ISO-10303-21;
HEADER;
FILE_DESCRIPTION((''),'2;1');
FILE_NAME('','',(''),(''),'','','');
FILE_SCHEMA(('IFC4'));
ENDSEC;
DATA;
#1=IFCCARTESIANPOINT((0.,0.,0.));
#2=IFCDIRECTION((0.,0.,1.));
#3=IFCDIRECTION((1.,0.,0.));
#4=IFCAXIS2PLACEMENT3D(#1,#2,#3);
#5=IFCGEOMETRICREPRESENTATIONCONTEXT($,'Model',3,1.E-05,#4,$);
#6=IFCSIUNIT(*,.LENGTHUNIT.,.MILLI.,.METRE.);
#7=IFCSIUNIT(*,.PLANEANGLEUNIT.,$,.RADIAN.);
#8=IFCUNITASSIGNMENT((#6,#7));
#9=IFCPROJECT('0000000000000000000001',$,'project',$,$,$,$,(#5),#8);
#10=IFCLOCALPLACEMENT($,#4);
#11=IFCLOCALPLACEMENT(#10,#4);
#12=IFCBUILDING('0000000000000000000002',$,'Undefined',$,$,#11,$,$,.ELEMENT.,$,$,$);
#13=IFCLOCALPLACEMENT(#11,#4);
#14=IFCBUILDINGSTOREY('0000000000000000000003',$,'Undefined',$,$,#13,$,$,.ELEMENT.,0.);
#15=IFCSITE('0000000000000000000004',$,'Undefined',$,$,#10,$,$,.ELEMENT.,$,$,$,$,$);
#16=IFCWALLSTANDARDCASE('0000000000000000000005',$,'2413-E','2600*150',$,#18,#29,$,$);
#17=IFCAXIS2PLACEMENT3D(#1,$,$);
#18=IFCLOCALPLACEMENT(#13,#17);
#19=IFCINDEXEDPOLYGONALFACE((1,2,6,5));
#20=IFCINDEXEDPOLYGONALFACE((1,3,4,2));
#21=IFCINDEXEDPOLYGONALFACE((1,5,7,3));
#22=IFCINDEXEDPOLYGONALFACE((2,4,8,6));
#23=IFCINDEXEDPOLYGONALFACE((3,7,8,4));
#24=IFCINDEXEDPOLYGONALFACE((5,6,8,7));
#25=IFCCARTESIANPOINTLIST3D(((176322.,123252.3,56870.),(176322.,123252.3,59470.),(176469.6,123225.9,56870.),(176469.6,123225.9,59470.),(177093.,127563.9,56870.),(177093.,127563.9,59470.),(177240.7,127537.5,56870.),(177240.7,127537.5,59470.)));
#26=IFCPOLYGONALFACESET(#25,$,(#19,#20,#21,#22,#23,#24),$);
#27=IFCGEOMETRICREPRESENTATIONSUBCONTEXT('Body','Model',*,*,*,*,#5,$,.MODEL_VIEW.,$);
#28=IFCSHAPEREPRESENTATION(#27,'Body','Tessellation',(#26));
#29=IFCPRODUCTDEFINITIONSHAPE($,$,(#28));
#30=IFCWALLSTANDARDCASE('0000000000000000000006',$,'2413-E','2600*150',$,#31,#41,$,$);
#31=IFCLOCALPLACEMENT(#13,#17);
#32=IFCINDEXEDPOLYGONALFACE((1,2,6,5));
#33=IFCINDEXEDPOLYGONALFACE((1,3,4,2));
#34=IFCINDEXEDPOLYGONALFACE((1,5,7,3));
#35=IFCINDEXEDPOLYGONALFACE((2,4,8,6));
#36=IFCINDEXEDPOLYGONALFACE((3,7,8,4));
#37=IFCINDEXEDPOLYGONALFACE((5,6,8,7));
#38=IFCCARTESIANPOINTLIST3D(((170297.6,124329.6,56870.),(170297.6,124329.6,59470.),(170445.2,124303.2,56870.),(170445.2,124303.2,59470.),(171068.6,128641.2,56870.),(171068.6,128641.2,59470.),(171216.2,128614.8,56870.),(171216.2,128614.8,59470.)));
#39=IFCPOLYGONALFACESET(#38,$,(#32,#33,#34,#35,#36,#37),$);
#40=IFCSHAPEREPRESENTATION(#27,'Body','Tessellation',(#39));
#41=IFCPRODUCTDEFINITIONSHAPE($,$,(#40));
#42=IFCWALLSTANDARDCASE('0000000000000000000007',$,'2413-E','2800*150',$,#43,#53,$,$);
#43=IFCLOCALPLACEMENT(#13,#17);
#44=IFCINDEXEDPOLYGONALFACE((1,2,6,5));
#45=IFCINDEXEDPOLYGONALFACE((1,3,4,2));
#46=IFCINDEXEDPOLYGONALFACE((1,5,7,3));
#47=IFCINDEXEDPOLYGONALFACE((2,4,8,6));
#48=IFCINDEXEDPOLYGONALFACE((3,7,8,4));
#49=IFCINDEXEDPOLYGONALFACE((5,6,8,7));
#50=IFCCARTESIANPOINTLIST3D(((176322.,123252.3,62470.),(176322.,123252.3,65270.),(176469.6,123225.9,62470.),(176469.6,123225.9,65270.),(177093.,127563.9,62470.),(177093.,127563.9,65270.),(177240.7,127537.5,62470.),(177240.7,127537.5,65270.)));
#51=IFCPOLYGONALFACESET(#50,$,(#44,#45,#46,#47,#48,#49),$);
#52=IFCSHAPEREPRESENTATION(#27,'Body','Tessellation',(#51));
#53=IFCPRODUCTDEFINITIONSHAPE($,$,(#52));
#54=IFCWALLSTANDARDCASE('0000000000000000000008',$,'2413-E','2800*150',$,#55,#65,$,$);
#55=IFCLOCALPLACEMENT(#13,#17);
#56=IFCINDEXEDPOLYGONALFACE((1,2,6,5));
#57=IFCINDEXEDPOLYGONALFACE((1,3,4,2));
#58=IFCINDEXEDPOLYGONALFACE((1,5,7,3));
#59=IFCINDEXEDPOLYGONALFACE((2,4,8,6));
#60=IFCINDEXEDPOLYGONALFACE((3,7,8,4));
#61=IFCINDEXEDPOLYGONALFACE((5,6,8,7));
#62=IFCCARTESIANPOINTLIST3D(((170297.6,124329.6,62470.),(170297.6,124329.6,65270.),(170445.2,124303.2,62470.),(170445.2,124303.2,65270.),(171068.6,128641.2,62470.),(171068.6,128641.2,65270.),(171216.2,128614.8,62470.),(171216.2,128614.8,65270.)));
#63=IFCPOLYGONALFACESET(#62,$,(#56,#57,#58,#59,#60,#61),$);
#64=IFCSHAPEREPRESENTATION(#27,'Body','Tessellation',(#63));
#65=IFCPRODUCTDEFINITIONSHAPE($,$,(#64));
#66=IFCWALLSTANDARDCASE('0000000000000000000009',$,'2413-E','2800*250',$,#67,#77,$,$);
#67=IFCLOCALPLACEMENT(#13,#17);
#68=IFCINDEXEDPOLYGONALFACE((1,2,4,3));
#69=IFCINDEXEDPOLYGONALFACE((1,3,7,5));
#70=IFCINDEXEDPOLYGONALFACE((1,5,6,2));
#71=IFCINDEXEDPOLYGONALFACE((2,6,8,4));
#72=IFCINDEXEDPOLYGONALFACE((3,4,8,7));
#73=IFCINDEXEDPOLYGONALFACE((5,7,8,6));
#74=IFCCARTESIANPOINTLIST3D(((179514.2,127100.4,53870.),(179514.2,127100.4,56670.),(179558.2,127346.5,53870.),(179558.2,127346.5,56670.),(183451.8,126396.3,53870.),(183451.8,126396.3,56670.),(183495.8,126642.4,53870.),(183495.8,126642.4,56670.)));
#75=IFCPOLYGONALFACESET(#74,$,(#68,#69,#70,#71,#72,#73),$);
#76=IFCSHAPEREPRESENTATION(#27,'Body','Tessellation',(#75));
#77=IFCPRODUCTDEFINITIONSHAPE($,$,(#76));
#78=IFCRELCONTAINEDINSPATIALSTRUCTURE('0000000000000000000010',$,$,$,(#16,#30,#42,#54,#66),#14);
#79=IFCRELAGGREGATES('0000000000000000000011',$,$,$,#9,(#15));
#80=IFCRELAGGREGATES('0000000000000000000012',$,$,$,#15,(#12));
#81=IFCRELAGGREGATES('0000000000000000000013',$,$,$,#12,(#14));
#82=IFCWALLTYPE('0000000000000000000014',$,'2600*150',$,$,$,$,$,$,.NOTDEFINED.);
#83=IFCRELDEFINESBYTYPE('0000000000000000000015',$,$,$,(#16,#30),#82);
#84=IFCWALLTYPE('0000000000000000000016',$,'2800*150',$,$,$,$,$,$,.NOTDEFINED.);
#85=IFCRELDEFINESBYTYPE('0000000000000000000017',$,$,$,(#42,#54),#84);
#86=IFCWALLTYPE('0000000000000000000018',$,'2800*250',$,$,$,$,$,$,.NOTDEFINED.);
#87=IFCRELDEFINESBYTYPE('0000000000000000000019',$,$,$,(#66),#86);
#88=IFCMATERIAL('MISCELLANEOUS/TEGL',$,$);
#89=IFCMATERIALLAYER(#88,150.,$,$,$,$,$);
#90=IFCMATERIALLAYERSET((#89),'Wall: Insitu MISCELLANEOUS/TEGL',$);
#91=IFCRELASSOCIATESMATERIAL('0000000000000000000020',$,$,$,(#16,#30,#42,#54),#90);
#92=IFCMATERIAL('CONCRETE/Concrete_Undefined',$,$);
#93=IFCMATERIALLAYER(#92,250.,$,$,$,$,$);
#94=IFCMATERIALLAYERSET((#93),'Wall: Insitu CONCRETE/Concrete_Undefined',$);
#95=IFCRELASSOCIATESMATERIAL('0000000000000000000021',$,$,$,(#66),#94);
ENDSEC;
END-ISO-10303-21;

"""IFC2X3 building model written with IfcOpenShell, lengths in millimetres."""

from ifc_helpers import new_model, si_unit, frame, frame_2d, origin_with_axes, place, context, subcontext, project, spatial, rectangle, extrude, material, layer, layer_set, layer_usage, type_object, element, save


model = new_model("IFC2X3")

# Units and contexts
model_context = context("Model", 3, precision=1e-05, world=origin_with_axes())
body_context = subcontext(model_context, "Body", "Model", "MODEL_VIEW")
ifc_project = project(units=[si_unit("LENGTHUNIT", "METRE", prefix="MILLI"), si_unit("PLANEANGLEUNIT", "RADIAN")], contexts=[model_context])

# Site, building, storey
site_placement = place(None, origin_with_axes())
site = spatial("IfcSite", under=ifc_project, at=site_placement, Name="Undefined", CompositionType="ELEMENT")
building_placement = place(site_placement, origin_with_axes())
building = spatial("IfcBuilding", under=site, at=building_placement, Name="Undefined", CompositionType="ELEMENT")
storey_placement = place(building_placement, origin_with_axes())
storey = spatial("IfcBuildingStorey", under=building, at=storey_placement, Name="Undefined", CompositionType="ELEMENT", Elevation=0.0)

# Shared definitions
ifc_material_1 = material(Name="CONCRETE/Concrete_Undefined")

# Walls
ifc_material_2 = material(Name="MISCELLANEOUS/TEGL")
ifc_layer_1 = layer(ifc_material_2, 150.0)
ifc_layer_set_1 = layer_set([ifc_layer_1], Name="Wall: Insitu MISCELLANEOUS/TEGL")
wall_type_1 = type_object("IfcWallType", Name="2600*150", PredefinedType="NOTDEFINED")
ifc_layer_usage_1 = layer_usage(ifc_layer_set_1, "AXIS2", "POSITIVE", -75.0)
wall_1_placement = place(storey_placement, frame((176395.8, 123239.1, 56870.0), z_axis=(0.0, 0.0, 1.0), x_axis=(0.176032, 0.984385, 0.0)))
element("IfcWallStandardCase", 1, at=wall_1_placement, inside=storey, type_object=wall_type_1, material=ifc_layer_usage_1, Name="2413-E", Description="2600*150", context=body_context, shape_type="SweptSolid", body=[
    extrude(rectangle(XDim=4380.0, YDim=150.0, at=frame_2d((0.0, 2190.0), x_axis=(0.0, -1.0))), frame((0.0, 0.0, 0.0), z_axis=(0.0, 0.0, 1.0), x_axis=(0.0, -1.0, 0.0)), (0.0, 0.0, 1.0), 2600.0),
])
ifc_layer_usage_2 = layer_usage(ifc_layer_set_1, "AXIS2", "POSITIVE", -75.0)
wall_2_placement = place(storey_placement, frame((170371.4, 124316.4, 56870.0), z_axis=(0.0, 0.0, 1.0), x_axis=(0.176032, 0.984385, 0.0)))
element("IfcWallStandardCase", 2, at=wall_2_placement, inside=storey, type_object=wall_type_1, material=ifc_layer_usage_2, Name="2413-E", Description="2600*150", context=body_context, shape_type="SweptSolid", body=[
    extrude(rectangle(XDim=4380.0, YDim=150.0, at=frame_2d((0.0, 2190.0), x_axis=(0.0, -1.0))), frame((0.0, 0.0, 0.0), z_axis=(0.0, 0.0, 1.0), x_axis=(0.0, -1.0, 0.0)), (0.0, 0.0, 1.0), 2600.0),
])
ifc_layer_usage_3 = layer_usage(ifc_layer_set_1, "AXIS2", "POSITIVE", -75.0)
wall_type_2 = type_object("IfcWallType", Name="2800*150", PredefinedType="NOTDEFINED")
wall_3_placement = place(storey_placement, frame((176395.8, 123239.1, 62470.0), z_axis=(0.0, 0.0, 1.0), x_axis=(0.176032, 0.984385, 0.0)))
element("IfcWallStandardCase", 3, at=wall_3_placement, inside=storey, type_object=wall_type_2, material=ifc_layer_usage_3, Name="2413-E", Description="2800*150", context=body_context, shape_type="SweptSolid", body=[
    extrude(rectangle(XDim=4380.0, YDim=150.0, at=frame_2d((0.0, 2190.0), x_axis=(0.0, -1.0))), frame((0.0, 0.0, 0.0), z_axis=(0.0, 0.0, 1.0), x_axis=(0.0, -1.0, 0.0)), (0.0, 0.0, 1.0), 2800.0),
])
ifc_layer_usage_4 = layer_usage(ifc_layer_set_1, "AXIS2", "POSITIVE", -75.0)
wall_4_placement = place(storey_placement, frame((170371.4, 124316.4, 62470.0), z_axis=(0.0, 0.0, 1.0), x_axis=(0.176032, 0.984385, 0.0)))
element("IfcWallStandardCase", 4, at=wall_4_placement, inside=storey, type_object=wall_type_2, material=ifc_layer_usage_4, Name="2413-E", Description="2800*150", context=body_context, shape_type="SweptSolid", body=[
    extrude(rectangle(XDim=4380.0, YDim=150.0, at=frame_2d((0.0, 2190.0), x_axis=(0.0, -1.0))), frame((0.0, 0.0, 0.0), z_axis=(0.0, 0.0, 1.0), x_axis=(0.0, -1.0, 0.0)), (0.0, 0.0, 1.0), 2800.0),
])
ifc_layer_2 = layer(ifc_material_1, 250.0)
ifc_layer_set_2 = layer_set([ifc_layer_2], Name="Wall: Insitu CONCRETE/Concrete_Undefined")
ifc_layer_usage_5 = layer_usage(ifc_layer_set_2, "AXIS2", "POSITIVE", -125.0)
wall_type_3 = type_object("IfcWallType", Name="2800*250", PredefinedType="NOTDEFINED")
wall_5_placement = place(storey_placement, frame((179536.2, 127223.5, 53870.0), z_axis=(0.0, 0.0, 1.0), x_axis=(0.984385, -0.176032, 0.0)))
element("IfcWallStandardCase", 5, at=wall_5_placement, inside=storey, type_object=wall_type_3, material=ifc_layer_usage_5, Name="2413-E", Description="2800*250", context=body_context, shape_type="SweptSolid", body=[
    extrude(rectangle(XDim=4000.0, YDim=250.0, at=frame_2d((0.0, 2000.0), x_axis=(0.0, -1.0))), frame((0.0, 0.0, 0.0), z_axis=(0.0, 0.0, 1.0), x_axis=(0.0, -1.0, 0.0)), (0.0, 0.0, 1.0), 2800.0),
])

save(model, "model.ifc")
